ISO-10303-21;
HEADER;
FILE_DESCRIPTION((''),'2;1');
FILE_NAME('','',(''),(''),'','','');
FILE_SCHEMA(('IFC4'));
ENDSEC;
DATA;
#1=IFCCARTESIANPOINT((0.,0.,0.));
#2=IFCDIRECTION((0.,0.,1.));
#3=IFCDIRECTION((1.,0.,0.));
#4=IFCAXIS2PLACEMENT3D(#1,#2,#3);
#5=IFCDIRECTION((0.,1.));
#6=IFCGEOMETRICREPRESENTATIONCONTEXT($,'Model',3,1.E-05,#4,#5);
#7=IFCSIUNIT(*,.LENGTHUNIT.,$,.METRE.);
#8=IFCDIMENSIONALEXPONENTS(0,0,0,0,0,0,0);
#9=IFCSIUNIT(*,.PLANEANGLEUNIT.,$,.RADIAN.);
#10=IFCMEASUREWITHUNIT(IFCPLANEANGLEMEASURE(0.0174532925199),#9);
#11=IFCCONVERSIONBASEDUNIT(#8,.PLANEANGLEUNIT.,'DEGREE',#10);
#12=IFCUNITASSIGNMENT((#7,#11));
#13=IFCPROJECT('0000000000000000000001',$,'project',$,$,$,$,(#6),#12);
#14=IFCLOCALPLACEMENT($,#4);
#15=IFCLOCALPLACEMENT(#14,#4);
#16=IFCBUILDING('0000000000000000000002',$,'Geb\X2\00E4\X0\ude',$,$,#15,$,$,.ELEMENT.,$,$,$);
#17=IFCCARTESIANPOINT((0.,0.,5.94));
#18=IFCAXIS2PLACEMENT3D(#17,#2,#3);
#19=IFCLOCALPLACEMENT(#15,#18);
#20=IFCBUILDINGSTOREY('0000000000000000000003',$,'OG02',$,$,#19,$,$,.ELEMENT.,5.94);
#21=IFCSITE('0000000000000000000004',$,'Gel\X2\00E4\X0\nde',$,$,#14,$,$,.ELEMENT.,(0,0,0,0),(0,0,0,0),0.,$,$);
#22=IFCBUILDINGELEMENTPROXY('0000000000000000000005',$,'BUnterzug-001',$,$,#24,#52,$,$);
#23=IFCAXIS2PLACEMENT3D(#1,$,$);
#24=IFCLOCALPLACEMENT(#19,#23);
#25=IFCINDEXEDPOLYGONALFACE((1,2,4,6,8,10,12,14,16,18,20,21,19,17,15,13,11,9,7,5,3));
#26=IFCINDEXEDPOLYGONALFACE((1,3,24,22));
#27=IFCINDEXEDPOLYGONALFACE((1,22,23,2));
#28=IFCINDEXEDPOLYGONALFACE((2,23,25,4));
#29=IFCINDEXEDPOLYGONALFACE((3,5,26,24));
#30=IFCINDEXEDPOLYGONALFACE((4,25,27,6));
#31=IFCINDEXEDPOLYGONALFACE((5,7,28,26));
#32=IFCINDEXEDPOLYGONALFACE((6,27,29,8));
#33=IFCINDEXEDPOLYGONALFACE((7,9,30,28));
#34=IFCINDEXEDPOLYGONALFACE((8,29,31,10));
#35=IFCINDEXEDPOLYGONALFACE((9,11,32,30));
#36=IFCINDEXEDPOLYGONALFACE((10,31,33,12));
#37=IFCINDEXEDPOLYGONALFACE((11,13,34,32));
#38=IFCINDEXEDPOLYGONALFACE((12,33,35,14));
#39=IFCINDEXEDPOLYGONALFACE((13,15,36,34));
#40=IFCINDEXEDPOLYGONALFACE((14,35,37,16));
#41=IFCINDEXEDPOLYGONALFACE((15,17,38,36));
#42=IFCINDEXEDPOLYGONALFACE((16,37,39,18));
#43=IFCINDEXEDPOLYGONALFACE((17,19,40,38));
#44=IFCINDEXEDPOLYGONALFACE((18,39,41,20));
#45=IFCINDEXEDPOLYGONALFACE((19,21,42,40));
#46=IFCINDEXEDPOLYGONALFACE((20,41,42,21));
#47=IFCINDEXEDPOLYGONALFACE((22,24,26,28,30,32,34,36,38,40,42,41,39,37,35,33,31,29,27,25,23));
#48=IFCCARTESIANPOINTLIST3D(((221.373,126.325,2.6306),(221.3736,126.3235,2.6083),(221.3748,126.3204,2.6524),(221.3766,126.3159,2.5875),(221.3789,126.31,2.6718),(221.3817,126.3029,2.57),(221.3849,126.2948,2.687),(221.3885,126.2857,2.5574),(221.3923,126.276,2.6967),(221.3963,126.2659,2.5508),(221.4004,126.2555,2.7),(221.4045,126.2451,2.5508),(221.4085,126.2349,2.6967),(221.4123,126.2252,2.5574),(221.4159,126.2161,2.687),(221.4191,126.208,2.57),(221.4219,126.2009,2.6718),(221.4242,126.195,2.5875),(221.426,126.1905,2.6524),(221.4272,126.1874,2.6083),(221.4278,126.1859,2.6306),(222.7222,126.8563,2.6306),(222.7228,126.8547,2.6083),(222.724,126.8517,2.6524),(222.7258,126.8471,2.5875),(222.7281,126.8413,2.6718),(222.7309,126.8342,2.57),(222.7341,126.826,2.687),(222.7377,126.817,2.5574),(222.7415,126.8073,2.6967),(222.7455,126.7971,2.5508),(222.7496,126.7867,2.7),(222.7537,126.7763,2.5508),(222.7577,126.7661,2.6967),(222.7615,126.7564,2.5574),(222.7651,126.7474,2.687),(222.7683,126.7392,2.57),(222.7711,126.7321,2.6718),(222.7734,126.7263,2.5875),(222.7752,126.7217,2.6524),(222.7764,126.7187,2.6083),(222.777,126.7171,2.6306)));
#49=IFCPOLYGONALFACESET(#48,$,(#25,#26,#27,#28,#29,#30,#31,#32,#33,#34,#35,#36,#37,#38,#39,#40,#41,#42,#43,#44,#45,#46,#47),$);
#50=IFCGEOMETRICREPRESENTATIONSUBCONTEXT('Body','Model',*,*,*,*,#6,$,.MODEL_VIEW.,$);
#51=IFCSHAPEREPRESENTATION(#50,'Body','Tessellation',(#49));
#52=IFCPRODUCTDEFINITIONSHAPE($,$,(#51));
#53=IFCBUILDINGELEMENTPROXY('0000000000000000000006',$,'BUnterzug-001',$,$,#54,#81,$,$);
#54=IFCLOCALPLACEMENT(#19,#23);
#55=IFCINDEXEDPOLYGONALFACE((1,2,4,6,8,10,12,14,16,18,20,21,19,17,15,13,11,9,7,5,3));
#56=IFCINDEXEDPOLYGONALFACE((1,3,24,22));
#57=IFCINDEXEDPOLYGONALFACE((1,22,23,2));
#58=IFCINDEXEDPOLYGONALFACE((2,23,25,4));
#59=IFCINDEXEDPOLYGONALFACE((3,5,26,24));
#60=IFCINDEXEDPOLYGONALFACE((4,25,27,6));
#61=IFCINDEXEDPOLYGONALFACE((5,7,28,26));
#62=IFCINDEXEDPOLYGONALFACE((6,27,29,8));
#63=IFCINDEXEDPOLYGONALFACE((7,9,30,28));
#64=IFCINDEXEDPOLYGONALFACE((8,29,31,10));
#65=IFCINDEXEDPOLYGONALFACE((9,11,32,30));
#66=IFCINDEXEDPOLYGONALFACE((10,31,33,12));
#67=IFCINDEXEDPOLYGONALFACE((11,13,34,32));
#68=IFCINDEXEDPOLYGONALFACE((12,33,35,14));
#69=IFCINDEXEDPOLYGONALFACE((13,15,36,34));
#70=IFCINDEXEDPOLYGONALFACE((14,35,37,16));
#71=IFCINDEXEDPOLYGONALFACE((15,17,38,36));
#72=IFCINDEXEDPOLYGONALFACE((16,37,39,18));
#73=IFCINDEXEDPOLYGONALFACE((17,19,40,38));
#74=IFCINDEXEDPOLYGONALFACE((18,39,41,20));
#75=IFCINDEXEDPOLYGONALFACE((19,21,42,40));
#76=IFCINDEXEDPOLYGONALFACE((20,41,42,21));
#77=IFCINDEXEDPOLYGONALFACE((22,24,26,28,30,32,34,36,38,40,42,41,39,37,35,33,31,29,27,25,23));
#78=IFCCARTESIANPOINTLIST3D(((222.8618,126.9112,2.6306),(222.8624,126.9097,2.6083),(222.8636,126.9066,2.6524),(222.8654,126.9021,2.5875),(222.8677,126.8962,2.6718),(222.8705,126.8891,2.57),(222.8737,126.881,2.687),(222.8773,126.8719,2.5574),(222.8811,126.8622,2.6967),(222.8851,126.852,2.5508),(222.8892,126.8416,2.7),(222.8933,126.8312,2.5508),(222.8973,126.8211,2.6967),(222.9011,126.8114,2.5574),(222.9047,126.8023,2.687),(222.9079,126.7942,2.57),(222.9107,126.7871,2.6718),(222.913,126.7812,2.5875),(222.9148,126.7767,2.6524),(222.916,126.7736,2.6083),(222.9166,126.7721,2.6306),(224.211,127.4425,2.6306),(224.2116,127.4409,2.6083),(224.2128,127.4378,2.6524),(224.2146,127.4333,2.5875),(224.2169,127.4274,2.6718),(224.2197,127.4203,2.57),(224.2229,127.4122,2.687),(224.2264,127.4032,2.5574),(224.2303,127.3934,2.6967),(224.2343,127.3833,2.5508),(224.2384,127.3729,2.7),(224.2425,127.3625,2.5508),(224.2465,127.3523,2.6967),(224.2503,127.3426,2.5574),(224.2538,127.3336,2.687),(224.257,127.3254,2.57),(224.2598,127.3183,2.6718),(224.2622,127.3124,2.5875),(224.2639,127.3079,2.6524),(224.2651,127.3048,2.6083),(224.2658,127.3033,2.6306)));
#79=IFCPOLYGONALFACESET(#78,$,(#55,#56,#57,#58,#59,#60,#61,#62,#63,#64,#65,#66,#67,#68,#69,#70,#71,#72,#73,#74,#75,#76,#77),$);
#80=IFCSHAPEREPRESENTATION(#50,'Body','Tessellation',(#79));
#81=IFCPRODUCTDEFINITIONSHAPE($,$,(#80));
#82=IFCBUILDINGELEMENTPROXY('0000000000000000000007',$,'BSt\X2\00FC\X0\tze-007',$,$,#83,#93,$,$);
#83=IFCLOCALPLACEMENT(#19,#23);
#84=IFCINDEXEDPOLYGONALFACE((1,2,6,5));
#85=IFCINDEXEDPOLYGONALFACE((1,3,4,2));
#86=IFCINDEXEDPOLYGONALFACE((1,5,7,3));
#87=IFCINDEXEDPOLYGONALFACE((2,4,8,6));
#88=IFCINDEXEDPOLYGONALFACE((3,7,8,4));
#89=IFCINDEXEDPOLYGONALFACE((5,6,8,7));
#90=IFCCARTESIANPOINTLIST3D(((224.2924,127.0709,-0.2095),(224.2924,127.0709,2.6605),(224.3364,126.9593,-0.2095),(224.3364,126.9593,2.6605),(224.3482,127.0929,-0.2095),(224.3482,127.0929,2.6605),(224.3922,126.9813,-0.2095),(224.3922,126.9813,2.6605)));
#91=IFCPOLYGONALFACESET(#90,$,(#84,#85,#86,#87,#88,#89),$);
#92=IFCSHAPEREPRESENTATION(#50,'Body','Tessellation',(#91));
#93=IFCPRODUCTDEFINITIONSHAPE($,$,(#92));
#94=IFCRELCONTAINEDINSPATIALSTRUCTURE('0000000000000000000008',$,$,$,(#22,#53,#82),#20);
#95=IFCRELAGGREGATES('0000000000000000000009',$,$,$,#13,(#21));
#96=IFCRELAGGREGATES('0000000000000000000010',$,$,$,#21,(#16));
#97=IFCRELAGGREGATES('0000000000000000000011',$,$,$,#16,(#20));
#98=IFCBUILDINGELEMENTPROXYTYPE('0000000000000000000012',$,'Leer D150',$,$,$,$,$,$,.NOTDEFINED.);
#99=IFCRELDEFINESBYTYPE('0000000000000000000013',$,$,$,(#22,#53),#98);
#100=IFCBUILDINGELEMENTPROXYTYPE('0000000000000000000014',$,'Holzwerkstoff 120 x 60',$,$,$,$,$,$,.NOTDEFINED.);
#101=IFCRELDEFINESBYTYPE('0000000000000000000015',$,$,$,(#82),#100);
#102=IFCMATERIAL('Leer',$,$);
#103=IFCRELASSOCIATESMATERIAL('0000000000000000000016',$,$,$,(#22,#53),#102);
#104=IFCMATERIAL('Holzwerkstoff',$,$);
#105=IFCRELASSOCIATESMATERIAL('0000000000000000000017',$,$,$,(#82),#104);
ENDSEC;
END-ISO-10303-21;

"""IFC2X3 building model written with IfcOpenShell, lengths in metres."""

from ifc_helpers import new_model, entity, si_unit, converted_unit, direction, frame, frame_2d, origin_with_axes, origin_2d_with_axis, place, context, subcontext, project, spatial, rectangle, circle, extrude, material, type_object, element, save


model = new_model("IFC2X3")

# Units and contexts
model_context = context("Model", 3, precision=1e-05, world=origin_with_axes(), true_north=direction((0.0, 1.0)))
body_context = subcontext(model_context, "Body", "Model", "MODEL_VIEW")
ifc_project = project(units=[si_unit("LENGTHUNIT", "METRE"), converted_unit("PLANEANGLEUNIT", "DEGREE", entity("IfcPlaneAngleMeasure", 0.0174532925199), si_unit("PLANEANGLEUNIT", "RADIAN"), dimensions=[0, 0, 0, 0, 0, 0, 0])], contexts=[model_context])

# Site, building, storey
site_placement = place(None, origin_with_axes())
site = spatial("IfcSite", under=ifc_project, at=site_placement, Name="Gelände", CompositionType="ELEMENT", RefLatitude=(0, 0, 0, 0), RefLongitude=(0, 0, 0, 0), RefElevation=0.0)
building_placement = place(site_placement, origin_with_axes())
building = spatial("IfcBuilding", under=site, at=building_placement, Name="Gebäude", CompositionType="ELEMENT")
storey_placement = place(building_placement, frame((0.0, 0.0, 5.94), z_axis=(0.0, 0.0, 1.0), x_axis=(1.0, 0.0, 0.0)))
storey = spatial("IfcBuildingStorey", under=building, at=storey_placement, Name="OG02", CompositionType="ELEMENT", Elevation=5.94)

# Shared definitions
ifc_material_1 = material(Name="Holzwerkstoff")

# Building element proxies
ifc_material_2 = material(Name="Leer")
building_element_proxy_type_1 = type_object("IfcBuildingElementProxyType", Name="Leer D150", PredefinedType="NOTDEFINED")
for number, where, z_axis, x_axis, name in (
    (1, (221.4004, 126.2555, 2.7), (0.0, 0.0, 1.0), (0.366369, -0.93047, 0.0), "BUnterzug-001"),
    (2, (222.8892, 126.8416, 2.7), (0.0, 0.0, 1.0), (0.366369, -0.93047, 0.0), "BUnterzug-001"),
):
    element("IfcBuildingElementProxy", number, at=place(storey_placement, frame(where, z_axis=z_axis, x_axis=x_axis)), inside=storey, type_object=building_element_proxy_type_1, material=ifc_material_2, Name=name, context=body_context, shape_type="SweptSolid", body=[
        extrude(circle(Radius=0.075, at=frame_2d((-0.075, 0.0), x_axis=(1.0, 0.0))), frame((0.0, 0.0, 0.0), z_axis=(0.0, 1.0, 0.0), x_axis=(0.0, 0.0, 1.0)), (0.0, 0.0, 1.0), 1.45),
    ])
building_element_proxy_type_2 = type_object("IfcBuildingElementProxyType", Name="Holzwerkstoff 120 x 60", PredefinedType="NOTDEFINED")
proxy_1_placement = place(storey_placement, frame((224.3423, 127.0261, -0.2095), z_axis=(0.0, 0.0, 1.0), x_axis=(0.366369, -0.93047, 0.0)))
element("IfcBuildingElementProxy", 3, at=proxy_1_placement, inside=storey, type_object=building_element_proxy_type_2, material=ifc_material_1, Name="BStütze-007", context=body_context, shape_type="SweptSolid", body=[
    extrude(rectangle(XDim=0.12, YDim=0.06, at=origin_2d_with_axis()), origin_with_axes(), (0.0, 0.0, 1.0), 2.87),
])

save(model, "model.ifc")
